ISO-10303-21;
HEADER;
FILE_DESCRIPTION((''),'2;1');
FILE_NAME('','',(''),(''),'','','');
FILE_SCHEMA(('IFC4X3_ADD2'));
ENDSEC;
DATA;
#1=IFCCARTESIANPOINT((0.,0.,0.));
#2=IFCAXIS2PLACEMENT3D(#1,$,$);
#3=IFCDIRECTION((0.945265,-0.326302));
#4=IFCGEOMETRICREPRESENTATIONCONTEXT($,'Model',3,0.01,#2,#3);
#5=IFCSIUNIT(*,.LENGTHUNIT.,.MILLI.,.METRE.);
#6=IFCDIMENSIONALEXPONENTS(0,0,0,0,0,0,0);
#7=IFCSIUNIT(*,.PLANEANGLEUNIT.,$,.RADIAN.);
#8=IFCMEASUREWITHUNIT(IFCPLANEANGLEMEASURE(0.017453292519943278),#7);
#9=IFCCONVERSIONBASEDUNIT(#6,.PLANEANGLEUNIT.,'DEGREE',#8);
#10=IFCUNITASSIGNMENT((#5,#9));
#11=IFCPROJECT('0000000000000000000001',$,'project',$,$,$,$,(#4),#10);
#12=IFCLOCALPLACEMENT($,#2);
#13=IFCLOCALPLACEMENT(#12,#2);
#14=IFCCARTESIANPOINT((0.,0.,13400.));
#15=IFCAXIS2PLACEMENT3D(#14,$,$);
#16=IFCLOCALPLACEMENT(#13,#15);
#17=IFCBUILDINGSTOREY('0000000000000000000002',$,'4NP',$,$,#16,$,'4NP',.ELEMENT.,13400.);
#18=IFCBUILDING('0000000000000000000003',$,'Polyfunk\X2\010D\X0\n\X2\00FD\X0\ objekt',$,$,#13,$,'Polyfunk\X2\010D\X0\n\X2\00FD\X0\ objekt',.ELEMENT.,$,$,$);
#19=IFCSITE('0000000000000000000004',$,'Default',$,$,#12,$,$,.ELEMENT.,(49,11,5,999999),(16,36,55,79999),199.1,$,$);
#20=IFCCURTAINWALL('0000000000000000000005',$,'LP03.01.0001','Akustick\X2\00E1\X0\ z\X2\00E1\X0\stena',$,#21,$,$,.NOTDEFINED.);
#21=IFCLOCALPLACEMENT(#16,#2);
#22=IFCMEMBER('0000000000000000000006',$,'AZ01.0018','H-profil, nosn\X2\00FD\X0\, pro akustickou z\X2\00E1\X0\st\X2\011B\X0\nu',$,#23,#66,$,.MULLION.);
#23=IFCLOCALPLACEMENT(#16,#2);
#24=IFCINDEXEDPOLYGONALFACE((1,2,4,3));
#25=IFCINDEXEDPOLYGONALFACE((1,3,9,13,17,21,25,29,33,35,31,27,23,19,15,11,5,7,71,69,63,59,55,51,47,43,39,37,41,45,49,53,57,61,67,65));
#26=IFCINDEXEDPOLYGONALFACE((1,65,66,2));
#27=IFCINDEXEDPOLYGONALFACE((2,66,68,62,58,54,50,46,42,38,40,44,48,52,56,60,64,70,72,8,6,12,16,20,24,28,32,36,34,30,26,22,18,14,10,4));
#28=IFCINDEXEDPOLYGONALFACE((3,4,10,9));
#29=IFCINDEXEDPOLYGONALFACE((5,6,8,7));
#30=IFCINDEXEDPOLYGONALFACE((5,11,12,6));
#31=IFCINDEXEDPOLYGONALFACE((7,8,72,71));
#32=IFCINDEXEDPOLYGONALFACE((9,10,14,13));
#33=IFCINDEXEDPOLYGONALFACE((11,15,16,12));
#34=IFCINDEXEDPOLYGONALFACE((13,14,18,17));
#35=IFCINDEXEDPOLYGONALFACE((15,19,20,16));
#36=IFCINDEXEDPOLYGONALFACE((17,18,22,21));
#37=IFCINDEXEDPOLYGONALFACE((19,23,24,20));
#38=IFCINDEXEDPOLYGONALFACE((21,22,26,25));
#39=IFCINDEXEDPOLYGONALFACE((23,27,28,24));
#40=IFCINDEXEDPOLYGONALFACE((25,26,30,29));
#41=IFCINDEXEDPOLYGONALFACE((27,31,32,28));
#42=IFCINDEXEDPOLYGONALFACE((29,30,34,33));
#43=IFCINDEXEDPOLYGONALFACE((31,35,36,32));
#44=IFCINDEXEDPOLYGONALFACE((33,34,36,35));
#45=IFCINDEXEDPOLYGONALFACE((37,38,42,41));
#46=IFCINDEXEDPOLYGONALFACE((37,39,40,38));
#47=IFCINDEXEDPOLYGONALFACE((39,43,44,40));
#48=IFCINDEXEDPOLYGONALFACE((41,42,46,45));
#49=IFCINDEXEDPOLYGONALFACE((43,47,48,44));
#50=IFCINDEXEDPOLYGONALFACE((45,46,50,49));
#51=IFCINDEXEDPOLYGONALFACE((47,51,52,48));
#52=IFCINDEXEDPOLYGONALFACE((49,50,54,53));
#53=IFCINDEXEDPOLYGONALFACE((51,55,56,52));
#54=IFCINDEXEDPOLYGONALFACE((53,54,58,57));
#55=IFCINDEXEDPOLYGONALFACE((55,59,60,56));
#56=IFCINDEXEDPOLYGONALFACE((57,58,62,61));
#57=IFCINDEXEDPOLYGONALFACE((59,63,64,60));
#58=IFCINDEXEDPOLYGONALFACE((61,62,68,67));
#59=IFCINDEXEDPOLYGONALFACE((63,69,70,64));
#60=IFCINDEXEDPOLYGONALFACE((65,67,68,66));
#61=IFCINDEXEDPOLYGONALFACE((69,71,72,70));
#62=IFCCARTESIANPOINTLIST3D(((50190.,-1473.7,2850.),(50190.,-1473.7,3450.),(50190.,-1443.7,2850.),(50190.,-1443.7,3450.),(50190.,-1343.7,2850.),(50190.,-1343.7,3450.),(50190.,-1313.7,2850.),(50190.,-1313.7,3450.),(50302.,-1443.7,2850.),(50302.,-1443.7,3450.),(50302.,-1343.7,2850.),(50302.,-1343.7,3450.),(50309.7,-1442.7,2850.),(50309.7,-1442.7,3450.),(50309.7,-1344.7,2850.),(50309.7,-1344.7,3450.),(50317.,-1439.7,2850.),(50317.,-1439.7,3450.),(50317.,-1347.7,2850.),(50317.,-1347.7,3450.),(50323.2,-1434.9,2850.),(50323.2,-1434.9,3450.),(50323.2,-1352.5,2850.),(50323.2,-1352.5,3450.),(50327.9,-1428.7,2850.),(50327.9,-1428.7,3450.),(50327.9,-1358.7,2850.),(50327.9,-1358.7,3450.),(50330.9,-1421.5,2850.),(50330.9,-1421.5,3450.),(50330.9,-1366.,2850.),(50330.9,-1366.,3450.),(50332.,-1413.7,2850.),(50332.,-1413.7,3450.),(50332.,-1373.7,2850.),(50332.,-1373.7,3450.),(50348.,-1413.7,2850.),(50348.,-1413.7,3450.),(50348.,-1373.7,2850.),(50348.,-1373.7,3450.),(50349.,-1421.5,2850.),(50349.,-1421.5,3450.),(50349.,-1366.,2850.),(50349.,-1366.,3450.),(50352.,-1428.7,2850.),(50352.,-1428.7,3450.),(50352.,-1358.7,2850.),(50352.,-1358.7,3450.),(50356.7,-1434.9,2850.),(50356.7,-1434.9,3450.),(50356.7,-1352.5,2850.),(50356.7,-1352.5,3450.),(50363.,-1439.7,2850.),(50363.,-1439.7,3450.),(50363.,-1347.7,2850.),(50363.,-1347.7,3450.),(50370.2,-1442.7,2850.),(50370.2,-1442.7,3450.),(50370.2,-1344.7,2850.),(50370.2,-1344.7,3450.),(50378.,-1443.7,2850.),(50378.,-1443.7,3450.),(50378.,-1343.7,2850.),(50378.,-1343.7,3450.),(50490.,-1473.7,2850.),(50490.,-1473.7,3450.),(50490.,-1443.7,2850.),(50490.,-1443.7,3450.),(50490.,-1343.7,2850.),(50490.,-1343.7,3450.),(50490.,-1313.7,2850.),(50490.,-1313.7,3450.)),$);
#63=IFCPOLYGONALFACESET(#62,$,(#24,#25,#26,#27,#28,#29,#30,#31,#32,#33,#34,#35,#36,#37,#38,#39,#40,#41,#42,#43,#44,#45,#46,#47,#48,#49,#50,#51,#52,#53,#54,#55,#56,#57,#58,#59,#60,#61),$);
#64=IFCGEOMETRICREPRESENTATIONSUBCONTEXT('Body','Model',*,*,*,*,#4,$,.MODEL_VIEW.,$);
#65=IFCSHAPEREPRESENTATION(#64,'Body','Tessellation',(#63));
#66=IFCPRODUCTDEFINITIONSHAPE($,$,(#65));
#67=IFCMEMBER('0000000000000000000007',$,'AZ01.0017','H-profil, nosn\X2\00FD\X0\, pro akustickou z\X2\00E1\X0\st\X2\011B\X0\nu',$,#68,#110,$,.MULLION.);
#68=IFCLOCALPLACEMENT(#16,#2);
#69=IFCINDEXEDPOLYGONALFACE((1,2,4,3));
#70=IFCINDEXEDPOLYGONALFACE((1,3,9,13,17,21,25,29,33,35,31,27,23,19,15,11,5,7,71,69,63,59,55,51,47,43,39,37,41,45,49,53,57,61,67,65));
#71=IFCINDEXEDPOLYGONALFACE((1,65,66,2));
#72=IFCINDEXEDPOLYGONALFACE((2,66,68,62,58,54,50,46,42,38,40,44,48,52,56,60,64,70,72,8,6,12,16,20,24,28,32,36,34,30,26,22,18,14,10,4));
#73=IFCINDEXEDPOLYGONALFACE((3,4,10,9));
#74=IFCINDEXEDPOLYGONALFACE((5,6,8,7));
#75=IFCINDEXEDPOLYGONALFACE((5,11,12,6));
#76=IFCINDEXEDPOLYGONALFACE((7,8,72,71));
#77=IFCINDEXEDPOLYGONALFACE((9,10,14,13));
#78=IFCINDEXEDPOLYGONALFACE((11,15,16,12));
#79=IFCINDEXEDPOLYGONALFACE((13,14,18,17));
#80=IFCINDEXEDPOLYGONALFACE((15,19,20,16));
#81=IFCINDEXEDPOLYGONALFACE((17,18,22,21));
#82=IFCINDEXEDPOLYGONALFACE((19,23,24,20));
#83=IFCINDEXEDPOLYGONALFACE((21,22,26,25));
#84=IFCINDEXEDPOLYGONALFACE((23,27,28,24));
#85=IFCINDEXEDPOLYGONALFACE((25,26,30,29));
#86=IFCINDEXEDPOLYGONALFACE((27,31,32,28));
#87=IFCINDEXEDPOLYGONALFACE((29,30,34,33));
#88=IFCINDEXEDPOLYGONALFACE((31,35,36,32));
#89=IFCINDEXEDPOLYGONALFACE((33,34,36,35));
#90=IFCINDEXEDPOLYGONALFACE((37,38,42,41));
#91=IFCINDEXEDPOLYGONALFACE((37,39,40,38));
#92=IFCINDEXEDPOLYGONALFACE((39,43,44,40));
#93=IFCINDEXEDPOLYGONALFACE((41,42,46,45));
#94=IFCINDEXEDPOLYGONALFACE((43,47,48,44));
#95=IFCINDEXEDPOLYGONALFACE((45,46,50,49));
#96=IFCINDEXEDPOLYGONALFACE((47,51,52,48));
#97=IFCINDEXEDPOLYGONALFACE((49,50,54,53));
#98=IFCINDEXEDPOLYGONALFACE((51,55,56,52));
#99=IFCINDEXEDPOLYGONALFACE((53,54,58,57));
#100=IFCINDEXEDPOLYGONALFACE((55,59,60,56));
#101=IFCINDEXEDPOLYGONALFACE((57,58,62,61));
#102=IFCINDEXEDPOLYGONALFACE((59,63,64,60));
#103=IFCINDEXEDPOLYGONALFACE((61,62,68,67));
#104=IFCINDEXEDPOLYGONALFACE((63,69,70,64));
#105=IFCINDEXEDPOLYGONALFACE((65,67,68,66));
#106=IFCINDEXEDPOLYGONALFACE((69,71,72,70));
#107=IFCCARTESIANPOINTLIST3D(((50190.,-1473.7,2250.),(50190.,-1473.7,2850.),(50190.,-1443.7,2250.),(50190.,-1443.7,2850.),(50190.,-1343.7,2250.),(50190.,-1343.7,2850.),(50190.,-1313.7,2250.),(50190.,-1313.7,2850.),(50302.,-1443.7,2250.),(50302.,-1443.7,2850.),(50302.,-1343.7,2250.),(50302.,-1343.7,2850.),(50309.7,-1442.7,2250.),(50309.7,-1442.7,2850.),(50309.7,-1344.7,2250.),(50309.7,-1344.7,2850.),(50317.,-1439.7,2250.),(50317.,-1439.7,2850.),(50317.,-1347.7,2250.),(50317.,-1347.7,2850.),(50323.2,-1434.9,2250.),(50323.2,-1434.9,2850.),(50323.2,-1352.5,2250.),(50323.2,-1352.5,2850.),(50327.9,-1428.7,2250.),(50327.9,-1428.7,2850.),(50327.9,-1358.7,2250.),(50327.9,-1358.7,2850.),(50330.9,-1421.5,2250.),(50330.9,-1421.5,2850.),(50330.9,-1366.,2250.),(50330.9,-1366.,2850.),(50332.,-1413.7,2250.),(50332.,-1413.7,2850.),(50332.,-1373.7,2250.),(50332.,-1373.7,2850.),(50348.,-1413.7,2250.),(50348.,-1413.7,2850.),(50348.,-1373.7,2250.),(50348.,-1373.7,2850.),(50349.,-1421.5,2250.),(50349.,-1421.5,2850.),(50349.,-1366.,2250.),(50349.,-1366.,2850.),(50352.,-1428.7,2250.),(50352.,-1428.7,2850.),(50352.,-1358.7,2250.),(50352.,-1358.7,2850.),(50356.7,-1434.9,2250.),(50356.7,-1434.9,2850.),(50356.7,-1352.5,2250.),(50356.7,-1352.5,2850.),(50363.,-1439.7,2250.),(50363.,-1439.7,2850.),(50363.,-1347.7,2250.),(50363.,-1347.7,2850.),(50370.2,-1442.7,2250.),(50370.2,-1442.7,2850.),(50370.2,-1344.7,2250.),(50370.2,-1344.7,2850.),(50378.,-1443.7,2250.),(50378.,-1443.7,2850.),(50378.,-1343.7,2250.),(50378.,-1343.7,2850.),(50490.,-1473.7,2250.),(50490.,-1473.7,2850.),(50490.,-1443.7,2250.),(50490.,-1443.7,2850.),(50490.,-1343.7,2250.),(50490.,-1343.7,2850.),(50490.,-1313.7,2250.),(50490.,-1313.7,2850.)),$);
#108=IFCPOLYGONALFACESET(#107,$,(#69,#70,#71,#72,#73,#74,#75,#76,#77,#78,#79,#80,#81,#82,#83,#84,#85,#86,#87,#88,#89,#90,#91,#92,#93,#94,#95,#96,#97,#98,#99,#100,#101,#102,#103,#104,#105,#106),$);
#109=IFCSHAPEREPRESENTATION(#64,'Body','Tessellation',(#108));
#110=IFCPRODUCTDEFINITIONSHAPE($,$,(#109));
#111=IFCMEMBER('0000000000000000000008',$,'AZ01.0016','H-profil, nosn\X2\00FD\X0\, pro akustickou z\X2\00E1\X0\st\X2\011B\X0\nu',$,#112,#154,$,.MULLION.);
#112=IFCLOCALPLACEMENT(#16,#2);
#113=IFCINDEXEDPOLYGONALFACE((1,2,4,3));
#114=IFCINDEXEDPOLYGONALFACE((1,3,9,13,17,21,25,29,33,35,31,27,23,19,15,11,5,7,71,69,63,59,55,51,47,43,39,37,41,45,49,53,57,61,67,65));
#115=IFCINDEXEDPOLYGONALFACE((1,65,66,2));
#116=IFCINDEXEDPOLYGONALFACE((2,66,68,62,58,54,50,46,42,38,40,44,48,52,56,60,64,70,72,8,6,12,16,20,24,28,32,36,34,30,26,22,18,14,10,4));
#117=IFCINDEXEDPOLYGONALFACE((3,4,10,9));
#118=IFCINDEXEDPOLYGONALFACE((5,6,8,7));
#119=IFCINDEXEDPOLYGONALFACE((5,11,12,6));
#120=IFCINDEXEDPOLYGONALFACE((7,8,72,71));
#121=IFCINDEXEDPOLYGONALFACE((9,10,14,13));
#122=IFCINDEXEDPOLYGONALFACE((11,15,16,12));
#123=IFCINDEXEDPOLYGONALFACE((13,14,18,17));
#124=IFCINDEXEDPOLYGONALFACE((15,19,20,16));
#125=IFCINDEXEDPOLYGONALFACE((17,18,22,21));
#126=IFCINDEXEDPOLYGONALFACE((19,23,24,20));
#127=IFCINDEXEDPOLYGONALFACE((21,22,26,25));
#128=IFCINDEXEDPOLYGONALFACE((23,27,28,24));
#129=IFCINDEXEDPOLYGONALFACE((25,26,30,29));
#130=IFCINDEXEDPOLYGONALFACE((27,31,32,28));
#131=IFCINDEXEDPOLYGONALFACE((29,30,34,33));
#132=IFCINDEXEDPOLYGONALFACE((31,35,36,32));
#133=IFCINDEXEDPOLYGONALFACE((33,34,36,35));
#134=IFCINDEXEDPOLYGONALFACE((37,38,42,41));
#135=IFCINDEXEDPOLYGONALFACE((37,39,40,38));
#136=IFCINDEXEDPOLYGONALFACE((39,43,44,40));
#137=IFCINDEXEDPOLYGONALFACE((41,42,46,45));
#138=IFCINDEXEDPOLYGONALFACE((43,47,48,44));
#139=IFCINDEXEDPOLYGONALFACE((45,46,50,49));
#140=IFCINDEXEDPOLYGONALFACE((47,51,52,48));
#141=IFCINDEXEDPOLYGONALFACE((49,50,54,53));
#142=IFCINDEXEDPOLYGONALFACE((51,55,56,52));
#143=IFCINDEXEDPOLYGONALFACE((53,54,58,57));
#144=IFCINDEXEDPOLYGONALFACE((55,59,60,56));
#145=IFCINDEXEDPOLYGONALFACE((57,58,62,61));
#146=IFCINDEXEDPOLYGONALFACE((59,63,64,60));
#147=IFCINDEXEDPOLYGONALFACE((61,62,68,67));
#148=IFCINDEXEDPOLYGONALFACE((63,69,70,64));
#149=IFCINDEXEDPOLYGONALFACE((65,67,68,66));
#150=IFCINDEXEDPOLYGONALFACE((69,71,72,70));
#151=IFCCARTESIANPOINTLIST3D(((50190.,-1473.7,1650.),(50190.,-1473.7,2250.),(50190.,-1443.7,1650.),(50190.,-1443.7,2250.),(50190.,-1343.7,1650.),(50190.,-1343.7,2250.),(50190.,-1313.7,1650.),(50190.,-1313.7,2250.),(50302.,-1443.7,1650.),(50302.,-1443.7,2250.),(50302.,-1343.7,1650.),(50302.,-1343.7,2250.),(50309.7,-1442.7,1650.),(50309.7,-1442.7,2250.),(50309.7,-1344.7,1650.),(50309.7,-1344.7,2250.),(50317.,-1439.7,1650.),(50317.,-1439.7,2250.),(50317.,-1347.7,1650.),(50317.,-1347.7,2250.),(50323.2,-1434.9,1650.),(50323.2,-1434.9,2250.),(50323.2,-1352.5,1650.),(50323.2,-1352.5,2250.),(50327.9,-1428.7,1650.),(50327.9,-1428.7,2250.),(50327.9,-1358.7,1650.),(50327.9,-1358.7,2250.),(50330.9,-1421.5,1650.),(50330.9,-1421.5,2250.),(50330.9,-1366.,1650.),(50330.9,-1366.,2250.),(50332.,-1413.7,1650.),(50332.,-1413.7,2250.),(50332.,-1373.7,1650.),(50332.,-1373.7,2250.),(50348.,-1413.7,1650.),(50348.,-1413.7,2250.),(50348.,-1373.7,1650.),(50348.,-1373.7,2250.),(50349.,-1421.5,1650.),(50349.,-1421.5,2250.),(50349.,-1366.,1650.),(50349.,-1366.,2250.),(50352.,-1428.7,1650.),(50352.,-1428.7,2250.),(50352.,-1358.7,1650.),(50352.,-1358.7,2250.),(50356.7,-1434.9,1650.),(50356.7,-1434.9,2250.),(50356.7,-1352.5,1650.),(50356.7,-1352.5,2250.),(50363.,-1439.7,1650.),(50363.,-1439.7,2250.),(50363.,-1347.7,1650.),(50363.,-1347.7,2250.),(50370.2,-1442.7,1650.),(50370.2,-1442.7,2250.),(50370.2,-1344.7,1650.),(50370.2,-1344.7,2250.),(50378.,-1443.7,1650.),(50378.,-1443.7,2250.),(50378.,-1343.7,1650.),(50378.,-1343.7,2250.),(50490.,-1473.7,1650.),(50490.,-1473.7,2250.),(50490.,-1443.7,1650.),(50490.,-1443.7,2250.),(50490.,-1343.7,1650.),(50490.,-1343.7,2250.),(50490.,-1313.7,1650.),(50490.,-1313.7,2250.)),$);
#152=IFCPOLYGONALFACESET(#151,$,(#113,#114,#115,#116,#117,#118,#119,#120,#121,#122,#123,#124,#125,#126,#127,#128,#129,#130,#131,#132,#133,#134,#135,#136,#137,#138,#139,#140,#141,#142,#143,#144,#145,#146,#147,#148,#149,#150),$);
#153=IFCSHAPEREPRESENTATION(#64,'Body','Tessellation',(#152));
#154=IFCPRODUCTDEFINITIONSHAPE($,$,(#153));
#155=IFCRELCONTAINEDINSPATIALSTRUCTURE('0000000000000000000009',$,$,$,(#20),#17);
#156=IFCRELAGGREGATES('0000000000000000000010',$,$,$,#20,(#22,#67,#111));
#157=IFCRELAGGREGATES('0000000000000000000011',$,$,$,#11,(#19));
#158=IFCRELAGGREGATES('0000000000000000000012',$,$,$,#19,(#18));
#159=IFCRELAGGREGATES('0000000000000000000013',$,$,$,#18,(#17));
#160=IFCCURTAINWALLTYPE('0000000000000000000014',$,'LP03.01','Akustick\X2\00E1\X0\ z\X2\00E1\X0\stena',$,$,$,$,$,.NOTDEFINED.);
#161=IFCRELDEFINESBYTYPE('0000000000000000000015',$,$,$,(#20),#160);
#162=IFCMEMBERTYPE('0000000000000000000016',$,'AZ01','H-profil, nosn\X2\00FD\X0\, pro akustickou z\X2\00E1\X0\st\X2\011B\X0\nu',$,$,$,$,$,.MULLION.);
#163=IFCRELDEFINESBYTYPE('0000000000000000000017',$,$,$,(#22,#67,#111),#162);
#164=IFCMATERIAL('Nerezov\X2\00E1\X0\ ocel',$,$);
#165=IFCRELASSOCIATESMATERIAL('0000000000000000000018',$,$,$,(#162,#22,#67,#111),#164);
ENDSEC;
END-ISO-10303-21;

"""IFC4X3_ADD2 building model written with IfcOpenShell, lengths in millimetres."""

from ifc_helpers import new_model, entity, si_unit, converted_unit, direction, frame, frame_2d, origin, place, context, subcontext, project, spatial, polyline, circle_curve, parameter, trimmed, segment, composite_curve, outline, extrude, source, transform, mapped, material, material_profile, profile_set, profile_usage, type_object, element, aggregate, save


model = new_model("IFC4X3_ADD2")

# Units and contexts
model_context = context("Model", 3, precision=0.01, world=origin(), true_north=direction((0.945265, -0.326302)))
body_context = subcontext(model_context, "Body", "Model", "MODEL_VIEW")
ifc_project = project(units=[si_unit("LENGTHUNIT", "METRE", prefix="MILLI"), converted_unit("PLANEANGLEUNIT", "DEGREE", entity("IfcPlaneAngleMeasure", 0.017453292519943278), si_unit("PLANEANGLEUNIT", "RADIAN"), dimensions=[0, 0, 0, 0, 0, 0, 0])], contexts=[model_context])

# Site, building, storey
site_placement = place(None, origin())
site = spatial("IfcSite", under=ifc_project, at=site_placement, Name="Default", CompositionType="ELEMENT", RefLatitude=(49, 11, 5, 999999), RefLongitude=(16, 36, 55, 79999), RefElevation=199.1)
building_placement = place(site_placement, origin())
building = spatial("IfcBuilding", under=site, at=building_placement, Name="Polyfunkčný objekt", LongName="Polyfunkčný objekt", CompositionType="ELEMENT")
storey_placement = place(building_placement, frame((0.0, 0.0, 13400.0)))
storey = spatial("IfcBuildingStorey", under=building, at=storey_placement, Name="4NP", LongName="4NP", CompositionType="ELEMENT", Elevation=13400.0)

# Curtain wall, members
curtain_wall_type = type_object("IfcCurtainWallType", Name="LP03.01", Description="Akustická zástena", PredefinedType="NOTDEFINED")
ifc_material_1 = material(Name="Nerezová ocel")
ifc_material_profile = material_profile(ifc_material_1, outline(composite_curve([segment(polyline([(50.0, -150.0), (80.0, -150.0)]), True, "CONTINUOUS"), segment(polyline([(80.0, -150.0), (80.0, 150.0)]), True, "CONTINUOUS"), segment(polyline([(80.0, 150.0), (50.0, 150.0)]), True, "CONTINUOUS"), segment(polyline([(50.0, 150.0), (50.0, 38.0)]), True, "CONTINUOUS"), segment(trimmed(circle_curve(frame_2d((20.0, 38.0), x_axis=(0.0, 1.0)), 30.0), [parameter(180.0)], [parameter(270.0)], True, "PARAMETER"), False, "CONTINUOUS"), segment(polyline([(20.0, 8.0), (-20.0, 8.0)]), True, "CONTINUOUS"), segment(trimmed(circle_curve(frame_2d((-20.0, 38.0), x_axis=(0.0, 1.0)), 30.0), [parameter(90.0)], [parameter(180.0)], True, "PARAMETER"), False, "CONTINUOUS"), segment(polyline([(-50.0, 38.0), (-50.0, 150.0)]), True, "CONTINUOUS"), segment(polyline([(-50.0, 150.0), (-80.0, 150.0)]), True, "CONTINUOUS"), segment(polyline([(-80.0, 150.0), (-80.0, -150.0)]), True, "CONTINUOUS"), segment(polyline([(-80.0, -150.0), (-50.0, -150.0)]), True, "CONTINUOUS"), segment(polyline([(-50.0, -150.0), (-50.0, -38.0)]), True, "CONTINUOUS"), segment(trimmed(circle_curve(frame_2d((-20.0, -38.0), x_axis=(0.0, 1.0)), 30.0), [parameter(0.0)], [parameter(90.0)], True, "PARAMETER"), False, "CONTINUOUS"), segment(polyline([(-20.0, -8.0), (20.0, -8.0)]), True, "CONTINUOUS"), segment(trimmed(circle_curve(frame_2d((20.0, -38.0), x_axis=(0.0, 1.0)), 30.0), [parameter(270.0)], [parameter(0.0)], True, "PARAMETER"), False, "CONTINUOUS"), segment(polyline([(50.0, -38.0), (50.0, -150.0)]), True, "CONTINUOUS")], self_intersect=False)), Name="Profil zástena")
ifc_profile_set = profile_set([ifc_material_profile], Name="Profil zástena")
ifc_profile_usage = profile_usage(ifc_profile_set)
member_type = type_object("IfcMemberType", Name="AZ01", Description="H-profil, nosný, pro akustickou zástěnu", PredefinedType="MULLION", material=ifc_profile_set)
shared_shape_1 = source(origin(), body_context, "Body", "SweptSolid", [
    extrude(outline(composite_curve([segment(polyline([(-150.0, -50.0), (-150.0, -80.0)]), True, "CONTINUOUS"), segment(polyline([(-150.0, -80.0), (150.0, -80.0)]), True, "CONTINUOUS"), segment(polyline([(150.0, -80.0), (150.0, -50.0)]), True, "CONTINUOUS"), segment(polyline([(150.0, -50.0), (38.0, -50.0)]), True, "CONTINUOUS"), segment(trimmed(circle_curve(frame_2d((38.0, -20.0), x_axis=(1.0, 0.0)), 30.0), [parameter(180.0)], [parameter(270.0)], True, "PARAMETER"), False, "CONTINUOUS"), segment(polyline([(8.0, -20.0), (8.0, 20.0)]), True, "CONTINUOUS"), segment(trimmed(circle_curve(frame_2d((38.0, 20.0), x_axis=(1.0, 0.0)), 30.0), [parameter(90.0)], [parameter(180.0)], True, "PARAMETER"), False, "CONTINUOUS"), segment(polyline([(38.0, 50.0), (150.0, 50.0)]), True, "CONTINUOUS"), segment(polyline([(150.0, 50.0), (150.0, 80.0)]), True, "CONTINUOUS"), segment(polyline([(150.0, 80.0), (-150.0, 80.0)]), True, "CONTINUOUS"), segment(polyline([(-150.0, 80.0), (-150.0, 50.0)]), True, "CONTINUOUS"), segment(polyline([(-150.0, 50.0), (-38.0, 50.0)]), True, "CONTINUOUS"), segment(trimmed(circle_curve(frame_2d((-38.0, 20.0), x_axis=(1.0, 0.0)), 30.0), [parameter(0.0)], [parameter(90.0)], True, "PARAMETER"), False, "CONTINUOUS"), segment(polyline([(-8.0, 20.0), (-8.0, -20.0)]), True, "CONTINUOUS"), segment(trimmed(circle_curve(frame_2d((-38.0, -20.0), x_axis=(1.0, 0.0)), 30.0), [parameter(270.0)], [parameter(0.0)], True, "PARAMETER"), False, "CONTINUOUS"), segment(polyline([(-38.0, -50.0), (-150.0, -50.0)]), True, "CONTINUOUS")], self_intersect=False)), frame((-150.0, 0.0, -600.0), z_axis=(0.0, 0.0, -1.0), x_axis=(-1.0, 0.0, 0.0)), (0.0, 0.0, -1.0), 600.0),
])
curtain_wall_1_placement = place(storey_placement, frame((0.0, 0.0, -13400.0)))
curtain_wall_1 = element("IfcCurtainWall", 1, at=curtain_wall_1_placement, inside=storey, type_object=curtain_wall_type, Name="LP03.01.0001", Description="Akustická zástena", PredefinedType="NOTDEFINED")
member_1_placement = place(curtain_wall_1_placement, frame((50190.0, -1393.7, 16850.0), z_axis=(0.0, 0.0, 1.0), x_axis=(-1.0, 0.0, 0.0)))
member_1 = element("IfcMember", 2, at=member_1_placement, type_object=member_type, material=ifc_profile_usage, Name="AZ01.0018", Description="H-profil, nosný, pro akustickou zástěnu", PredefinedType="MULLION", context=body_context, shape_type="MappedRepresentation", body=[
    mapped(shared_shape_1, transform((0.0, 0.0, 0.0), scale=1.0)),
])
member_2_placement = place(curtain_wall_1_placement, frame((50190.0, -1393.7, 16250.0), z_axis=(0.0, 0.0, 1.0), x_axis=(-1.0, 0.0, 0.0)))
member_2 = element("IfcMember", 3, at=member_2_placement, type_object=member_type, material=ifc_profile_usage, Name="AZ01.0017", Description="H-profil, nosný, pro akustickou zástěnu", PredefinedType="MULLION", context=body_context, shape_type="MappedRepresentation", body=[
    mapped(shared_shape_1, transform((0.0, 0.0, 0.0), scale=1.0)),
])
member_3_placement = place(curtain_wall_1_placement, frame((50190.0, -1393.7, 15650.0), z_axis=(0.0, 0.0, 1.0), x_axis=(-1.0, 0.0, 0.0)))
member_3 = element("IfcMember", 4, at=member_3_placement, type_object=member_type, material=ifc_profile_usage, Name="AZ01.0016", Description="H-profil, nosný, pro akustickou zástěnu", PredefinedType="MULLION", context=body_context, shape_type="MappedRepresentation", body=[
    mapped(shared_shape_1, transform((0.0, 0.0, 0.0), scale=1.0)),
])

aggregate(curtain_wall_1, [member_1, member_2, member_3])

save(model, "model.ifc")
